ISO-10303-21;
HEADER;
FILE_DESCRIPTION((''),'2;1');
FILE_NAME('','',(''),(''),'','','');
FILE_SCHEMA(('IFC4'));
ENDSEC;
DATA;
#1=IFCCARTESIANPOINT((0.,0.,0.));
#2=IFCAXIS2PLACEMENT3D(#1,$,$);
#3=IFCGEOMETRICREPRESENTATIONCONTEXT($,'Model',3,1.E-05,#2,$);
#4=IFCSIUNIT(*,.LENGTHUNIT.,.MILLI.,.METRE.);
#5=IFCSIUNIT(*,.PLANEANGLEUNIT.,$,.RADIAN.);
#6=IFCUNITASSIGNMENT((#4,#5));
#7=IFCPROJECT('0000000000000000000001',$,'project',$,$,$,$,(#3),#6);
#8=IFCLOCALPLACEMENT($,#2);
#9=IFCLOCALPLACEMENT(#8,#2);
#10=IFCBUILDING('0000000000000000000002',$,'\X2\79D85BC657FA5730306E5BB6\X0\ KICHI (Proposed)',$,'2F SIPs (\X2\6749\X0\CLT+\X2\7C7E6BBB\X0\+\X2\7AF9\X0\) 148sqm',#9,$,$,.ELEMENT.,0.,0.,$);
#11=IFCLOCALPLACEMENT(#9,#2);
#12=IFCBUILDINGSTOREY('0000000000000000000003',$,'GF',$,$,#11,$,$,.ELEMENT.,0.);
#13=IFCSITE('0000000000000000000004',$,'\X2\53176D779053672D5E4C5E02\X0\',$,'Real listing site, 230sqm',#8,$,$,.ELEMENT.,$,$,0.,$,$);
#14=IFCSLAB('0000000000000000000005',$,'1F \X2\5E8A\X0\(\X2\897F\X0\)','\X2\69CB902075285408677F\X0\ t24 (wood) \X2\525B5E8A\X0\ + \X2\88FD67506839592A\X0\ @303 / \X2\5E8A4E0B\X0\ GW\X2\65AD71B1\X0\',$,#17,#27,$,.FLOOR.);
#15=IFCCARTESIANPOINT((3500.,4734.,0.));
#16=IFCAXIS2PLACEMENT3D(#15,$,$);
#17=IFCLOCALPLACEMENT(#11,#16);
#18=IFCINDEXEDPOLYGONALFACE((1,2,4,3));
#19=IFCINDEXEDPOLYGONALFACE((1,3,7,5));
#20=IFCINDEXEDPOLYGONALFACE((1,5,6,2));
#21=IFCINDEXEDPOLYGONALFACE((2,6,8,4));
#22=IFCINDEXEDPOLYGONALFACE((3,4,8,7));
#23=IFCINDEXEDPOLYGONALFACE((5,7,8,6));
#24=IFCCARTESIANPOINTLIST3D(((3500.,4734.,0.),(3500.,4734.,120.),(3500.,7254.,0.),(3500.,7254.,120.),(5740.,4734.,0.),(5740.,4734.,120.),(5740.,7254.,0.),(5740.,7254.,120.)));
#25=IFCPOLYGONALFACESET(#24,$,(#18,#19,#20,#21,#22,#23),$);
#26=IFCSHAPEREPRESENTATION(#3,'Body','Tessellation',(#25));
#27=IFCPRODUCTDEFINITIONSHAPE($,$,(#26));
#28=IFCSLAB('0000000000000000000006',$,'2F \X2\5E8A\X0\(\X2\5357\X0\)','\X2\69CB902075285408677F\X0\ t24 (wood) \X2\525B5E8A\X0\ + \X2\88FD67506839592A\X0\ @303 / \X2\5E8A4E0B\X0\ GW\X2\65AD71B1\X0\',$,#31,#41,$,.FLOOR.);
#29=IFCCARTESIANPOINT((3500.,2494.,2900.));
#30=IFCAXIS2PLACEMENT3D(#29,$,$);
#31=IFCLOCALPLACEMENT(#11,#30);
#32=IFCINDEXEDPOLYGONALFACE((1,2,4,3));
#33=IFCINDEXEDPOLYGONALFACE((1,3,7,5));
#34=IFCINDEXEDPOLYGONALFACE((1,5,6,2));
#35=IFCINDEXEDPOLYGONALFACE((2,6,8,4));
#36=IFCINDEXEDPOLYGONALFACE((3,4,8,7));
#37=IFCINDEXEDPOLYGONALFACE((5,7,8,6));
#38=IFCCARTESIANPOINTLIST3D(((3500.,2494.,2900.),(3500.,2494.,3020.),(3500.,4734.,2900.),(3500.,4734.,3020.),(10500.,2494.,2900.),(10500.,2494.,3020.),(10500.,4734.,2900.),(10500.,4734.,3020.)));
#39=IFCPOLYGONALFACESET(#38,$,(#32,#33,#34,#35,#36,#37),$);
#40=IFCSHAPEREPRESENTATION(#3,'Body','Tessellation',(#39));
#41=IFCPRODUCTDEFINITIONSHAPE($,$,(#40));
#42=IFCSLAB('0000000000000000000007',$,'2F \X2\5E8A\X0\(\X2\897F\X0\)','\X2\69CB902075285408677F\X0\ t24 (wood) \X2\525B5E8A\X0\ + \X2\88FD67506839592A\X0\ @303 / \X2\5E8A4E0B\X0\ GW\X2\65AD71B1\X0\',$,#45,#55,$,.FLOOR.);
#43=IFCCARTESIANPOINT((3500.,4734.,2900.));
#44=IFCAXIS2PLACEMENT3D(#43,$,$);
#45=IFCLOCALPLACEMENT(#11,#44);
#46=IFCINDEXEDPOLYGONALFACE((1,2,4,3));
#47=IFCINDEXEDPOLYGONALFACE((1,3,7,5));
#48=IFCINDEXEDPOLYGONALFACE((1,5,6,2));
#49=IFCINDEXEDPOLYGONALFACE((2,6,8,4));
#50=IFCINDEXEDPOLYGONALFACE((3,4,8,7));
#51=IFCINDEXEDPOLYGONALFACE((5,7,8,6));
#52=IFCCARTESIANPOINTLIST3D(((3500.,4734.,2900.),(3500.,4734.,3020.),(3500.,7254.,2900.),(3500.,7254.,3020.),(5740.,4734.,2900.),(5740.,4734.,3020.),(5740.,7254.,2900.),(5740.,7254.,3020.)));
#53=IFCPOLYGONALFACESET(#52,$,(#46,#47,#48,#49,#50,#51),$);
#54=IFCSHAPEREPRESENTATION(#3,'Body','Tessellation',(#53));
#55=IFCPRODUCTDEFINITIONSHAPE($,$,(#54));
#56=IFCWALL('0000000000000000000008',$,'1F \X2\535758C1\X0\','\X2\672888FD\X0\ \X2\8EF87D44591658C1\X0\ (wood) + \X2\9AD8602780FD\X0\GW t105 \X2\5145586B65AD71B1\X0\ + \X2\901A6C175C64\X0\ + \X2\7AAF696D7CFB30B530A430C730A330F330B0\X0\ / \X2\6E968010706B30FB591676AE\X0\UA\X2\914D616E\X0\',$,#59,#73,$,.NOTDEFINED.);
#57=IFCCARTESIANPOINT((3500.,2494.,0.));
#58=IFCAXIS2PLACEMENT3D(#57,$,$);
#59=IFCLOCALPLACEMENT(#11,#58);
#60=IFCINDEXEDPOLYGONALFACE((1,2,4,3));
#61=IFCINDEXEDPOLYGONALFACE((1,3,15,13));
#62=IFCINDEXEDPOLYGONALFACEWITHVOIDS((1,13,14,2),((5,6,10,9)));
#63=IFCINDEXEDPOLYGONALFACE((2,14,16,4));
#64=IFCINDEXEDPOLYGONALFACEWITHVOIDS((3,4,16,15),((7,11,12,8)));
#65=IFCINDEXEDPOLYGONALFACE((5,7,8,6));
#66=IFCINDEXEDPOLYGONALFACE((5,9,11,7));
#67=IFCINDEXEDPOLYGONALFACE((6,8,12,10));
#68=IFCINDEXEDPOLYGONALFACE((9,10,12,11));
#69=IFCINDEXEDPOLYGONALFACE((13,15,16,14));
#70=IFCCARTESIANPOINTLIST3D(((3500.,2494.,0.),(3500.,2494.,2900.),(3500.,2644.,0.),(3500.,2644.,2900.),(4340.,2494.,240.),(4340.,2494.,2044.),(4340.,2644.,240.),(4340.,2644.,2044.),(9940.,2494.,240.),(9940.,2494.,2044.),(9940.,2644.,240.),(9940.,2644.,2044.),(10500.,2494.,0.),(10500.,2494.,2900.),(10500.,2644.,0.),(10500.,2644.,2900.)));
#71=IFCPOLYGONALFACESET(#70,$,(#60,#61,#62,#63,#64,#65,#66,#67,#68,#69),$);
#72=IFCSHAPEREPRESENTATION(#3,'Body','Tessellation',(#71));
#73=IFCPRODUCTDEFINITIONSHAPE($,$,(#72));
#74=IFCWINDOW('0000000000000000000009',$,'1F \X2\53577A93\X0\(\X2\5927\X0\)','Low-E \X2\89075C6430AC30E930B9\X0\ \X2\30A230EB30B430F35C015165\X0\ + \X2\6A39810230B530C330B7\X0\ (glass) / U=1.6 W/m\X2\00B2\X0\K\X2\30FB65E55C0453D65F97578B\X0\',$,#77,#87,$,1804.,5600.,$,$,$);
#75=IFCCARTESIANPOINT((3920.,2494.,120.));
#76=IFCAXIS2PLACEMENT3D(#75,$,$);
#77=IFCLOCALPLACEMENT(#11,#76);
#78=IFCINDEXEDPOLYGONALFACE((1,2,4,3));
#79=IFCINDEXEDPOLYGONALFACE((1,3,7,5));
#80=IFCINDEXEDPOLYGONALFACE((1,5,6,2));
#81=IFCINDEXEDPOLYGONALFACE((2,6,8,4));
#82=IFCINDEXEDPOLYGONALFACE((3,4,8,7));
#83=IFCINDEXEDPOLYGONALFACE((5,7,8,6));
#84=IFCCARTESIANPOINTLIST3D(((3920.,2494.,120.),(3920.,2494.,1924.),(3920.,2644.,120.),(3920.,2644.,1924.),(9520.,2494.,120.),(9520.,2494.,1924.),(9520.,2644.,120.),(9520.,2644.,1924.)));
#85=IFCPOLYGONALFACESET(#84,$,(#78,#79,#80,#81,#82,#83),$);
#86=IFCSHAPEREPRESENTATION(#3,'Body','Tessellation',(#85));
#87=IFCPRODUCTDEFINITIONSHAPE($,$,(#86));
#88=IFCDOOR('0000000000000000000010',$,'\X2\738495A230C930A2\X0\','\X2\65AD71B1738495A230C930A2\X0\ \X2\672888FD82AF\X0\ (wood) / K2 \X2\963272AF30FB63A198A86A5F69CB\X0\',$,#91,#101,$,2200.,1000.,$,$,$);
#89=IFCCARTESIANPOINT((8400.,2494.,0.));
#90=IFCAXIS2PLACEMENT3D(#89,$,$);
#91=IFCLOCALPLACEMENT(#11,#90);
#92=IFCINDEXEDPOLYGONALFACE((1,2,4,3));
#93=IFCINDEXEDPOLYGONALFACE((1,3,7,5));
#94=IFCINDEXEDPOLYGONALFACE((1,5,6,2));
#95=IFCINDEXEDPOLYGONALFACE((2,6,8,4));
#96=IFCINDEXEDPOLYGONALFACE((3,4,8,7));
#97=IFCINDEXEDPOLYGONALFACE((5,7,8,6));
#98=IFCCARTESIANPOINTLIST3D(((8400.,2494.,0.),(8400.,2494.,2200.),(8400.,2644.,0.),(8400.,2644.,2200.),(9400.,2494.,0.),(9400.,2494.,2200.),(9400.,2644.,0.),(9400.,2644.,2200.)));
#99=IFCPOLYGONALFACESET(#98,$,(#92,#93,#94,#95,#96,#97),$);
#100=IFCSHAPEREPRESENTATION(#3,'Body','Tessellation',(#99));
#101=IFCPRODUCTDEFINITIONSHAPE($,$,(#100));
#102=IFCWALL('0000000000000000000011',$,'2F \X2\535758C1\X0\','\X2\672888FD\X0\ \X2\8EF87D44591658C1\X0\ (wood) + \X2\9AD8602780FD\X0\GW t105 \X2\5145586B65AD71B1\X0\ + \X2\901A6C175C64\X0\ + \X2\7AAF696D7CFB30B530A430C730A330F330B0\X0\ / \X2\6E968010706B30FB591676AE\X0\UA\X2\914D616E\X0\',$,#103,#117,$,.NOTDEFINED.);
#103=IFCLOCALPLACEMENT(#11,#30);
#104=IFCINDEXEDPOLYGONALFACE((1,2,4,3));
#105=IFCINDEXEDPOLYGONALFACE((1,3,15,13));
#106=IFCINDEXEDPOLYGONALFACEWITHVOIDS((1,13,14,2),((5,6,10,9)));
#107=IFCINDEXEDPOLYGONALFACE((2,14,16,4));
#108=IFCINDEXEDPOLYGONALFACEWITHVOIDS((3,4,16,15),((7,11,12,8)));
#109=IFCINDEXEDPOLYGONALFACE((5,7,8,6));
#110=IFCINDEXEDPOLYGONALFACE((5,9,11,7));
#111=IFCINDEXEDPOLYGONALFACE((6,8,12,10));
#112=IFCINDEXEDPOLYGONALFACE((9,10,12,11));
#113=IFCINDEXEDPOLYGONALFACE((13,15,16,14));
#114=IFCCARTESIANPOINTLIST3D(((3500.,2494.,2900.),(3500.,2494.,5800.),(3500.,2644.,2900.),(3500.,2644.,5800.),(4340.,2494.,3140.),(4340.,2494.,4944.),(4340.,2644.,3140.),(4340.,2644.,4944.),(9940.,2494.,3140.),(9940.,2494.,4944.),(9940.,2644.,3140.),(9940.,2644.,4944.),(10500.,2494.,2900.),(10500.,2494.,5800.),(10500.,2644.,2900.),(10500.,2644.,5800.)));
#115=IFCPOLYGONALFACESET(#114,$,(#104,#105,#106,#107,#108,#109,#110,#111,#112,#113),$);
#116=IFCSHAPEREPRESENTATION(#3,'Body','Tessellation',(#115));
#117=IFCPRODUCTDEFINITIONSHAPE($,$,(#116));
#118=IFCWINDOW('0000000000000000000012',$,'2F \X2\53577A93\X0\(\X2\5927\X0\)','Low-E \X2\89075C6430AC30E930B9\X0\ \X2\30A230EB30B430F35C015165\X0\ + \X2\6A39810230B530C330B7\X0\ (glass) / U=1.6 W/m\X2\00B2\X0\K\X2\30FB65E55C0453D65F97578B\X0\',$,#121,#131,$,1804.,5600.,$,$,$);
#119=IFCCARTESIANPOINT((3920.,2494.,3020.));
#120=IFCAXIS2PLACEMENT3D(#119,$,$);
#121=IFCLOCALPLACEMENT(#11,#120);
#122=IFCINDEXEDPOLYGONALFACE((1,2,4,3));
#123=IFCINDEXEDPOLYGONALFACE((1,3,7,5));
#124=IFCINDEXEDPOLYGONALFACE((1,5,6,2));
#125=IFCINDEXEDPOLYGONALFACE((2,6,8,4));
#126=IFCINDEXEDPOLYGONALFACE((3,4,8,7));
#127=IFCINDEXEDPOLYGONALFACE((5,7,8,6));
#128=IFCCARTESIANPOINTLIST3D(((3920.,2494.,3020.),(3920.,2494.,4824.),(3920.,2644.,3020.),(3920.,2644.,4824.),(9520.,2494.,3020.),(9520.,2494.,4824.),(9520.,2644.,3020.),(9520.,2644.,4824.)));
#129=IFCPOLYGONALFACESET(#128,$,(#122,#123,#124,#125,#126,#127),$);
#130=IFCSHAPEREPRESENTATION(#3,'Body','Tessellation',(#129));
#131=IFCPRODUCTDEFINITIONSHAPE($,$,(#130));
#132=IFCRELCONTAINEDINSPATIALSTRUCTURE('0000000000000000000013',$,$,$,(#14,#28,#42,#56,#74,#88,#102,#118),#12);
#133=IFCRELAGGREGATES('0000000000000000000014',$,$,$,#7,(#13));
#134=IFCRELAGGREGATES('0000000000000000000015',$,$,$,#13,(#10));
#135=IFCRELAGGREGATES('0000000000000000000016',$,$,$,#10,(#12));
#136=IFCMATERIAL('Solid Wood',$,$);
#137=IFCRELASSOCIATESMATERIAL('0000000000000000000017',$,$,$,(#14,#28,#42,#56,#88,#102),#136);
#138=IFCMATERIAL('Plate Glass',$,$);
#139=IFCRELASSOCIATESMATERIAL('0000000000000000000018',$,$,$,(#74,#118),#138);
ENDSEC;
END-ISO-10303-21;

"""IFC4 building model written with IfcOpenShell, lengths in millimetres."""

from ifc_helpers import new_model, si_unit, frame, frame_2d, origin, place, context, project, spatial, rectangle, extrude, material, element, fill, save


model = new_model("IFC4")

# Units and contexts
model_context = context("Model", 3, precision=1e-05, world=origin())
ifc_project = project(units=[si_unit("LENGTHUNIT", "METRE", prefix="MILLI"), si_unit("PLANEANGLEUNIT", "RADIAN")], contexts=[model_context])

# Site, building, storey
site_placement = place(None, origin())
site = spatial("IfcSite", under=ifc_project, at=site_placement, Name="北海道札幌市", ObjectType="Real listing site, 230sqm", CompositionType="ELEMENT", RefElevation=0.0)
building_placement = place(site_placement, origin())
building = spatial("IfcBuilding", under=site, at=building_placement, Name="秘密基地の家 KICHI (Proposed)", ObjectType="2F SIPs (杉CLT+籾殻+竹) 148sqm", CompositionType="ELEMENT", ElevationOfRefHeight=0.0, ElevationOfTerrain=0.0)
storey_placement = place(building_placement, origin())
storey = spatial("IfcBuildingStorey", under=building, at=storey_placement, Name="GF", CompositionType="ELEMENT", Elevation=0.0)

# Slabs
ifc_material_1 = material(Name="Solid Wood")
slab_1_placement = place(storey_placement, frame((3500.0, 4734.0, 0.0)))
element("IfcSlab", 1, at=slab_1_placement, inside=storey, material=ifc_material_1, Name="1F 床(西)", Description="構造用合板 t24 (wood) 剛床 + 製材根太 @303 / 床下 GW断熱", PredefinedType="FLOOR", context=model_context, shape_type="SweptSolid", body=[
    extrude(rectangle(XDim=2240.0, YDim=2520.0, at=frame_2d((1120.0, 1260.0))), frame((3500.0, 4734.0, 0.0)), (0.0, 0.0, 1.0), 120.0),
])
slab_2_placement = place(storey_placement, frame((3500.0, 2494.0, 2900.0)))
element("IfcSlab", 2, at=slab_2_placement, inside=storey, material=ifc_material_1, Name="2F 床(南)", Description="構造用合板 t24 (wood) 剛床 + 製材根太 @303 / 床下 GW断熱", PredefinedType="FLOOR", context=model_context, shape_type="SweptSolid", body=[
    extrude(rectangle(XDim=7000.0, YDim=2240.0, at=frame_2d((3500.0, 1120.0))), frame((3500.0, 2494.0, 2900.0)), (0.0, 0.0, 1.0), 120.0),
])
slab_3_placement = place(storey_placement, frame((3500.0, 4734.0, 2900.0)))
element("IfcSlab", 3, at=slab_3_placement, inside=storey, material=ifc_material_1, Name="2F 床(西)", Description="構造用合板 t24 (wood) 剛床 + 製材根太 @303 / 床下 GW断熱", PredefinedType="FLOOR", context=model_context, shape_type="SweptSolid", body=[
    extrude(rectangle(XDim=2240.0, YDim=2520.0, at=frame_2d((1120.0, 1260.0))), frame((3500.0, 4734.0, 2900.0)), (0.0, 0.0, 1.0), 120.0),
])

# Wall, openings, window, door
wall_1_placement = place(storey_placement, frame((3500.0, 2494.0, 0.0)))
wall_1 = element("IfcWall", 4, at=wall_1_placement, inside=storey, material=ifc_material_1, Name="1F 南壁", Description="木製 軸組外壁 (wood) + 高性能GW t105 充填断熱 + 通気層 + 窯業系サイディング / 準耐火・外皮UA配慮", PredefinedType="NOTDEFINED", context=model_context, shape_type="SweptSolid", body=[
    extrude(rectangle(XDim=7000.0, YDim=150.0, at=frame_2d((3500.0, 75.0))), frame((3500.0, 2494.0, 0.0)), (0.0, 0.0, 1.0), 2900.0),
])
opening_1_placement = place(storey_placement, frame((3920.0, 2494.0, 120.0)))
opening_1 = element("IfcOpeningElement", 5, at=opening_1_placement, cuts=wall_1, PredefinedType="NOTDEFINED", context=model_context, shape_type="SweptSolid", body=[
    extrude(rectangle(XDim=5600.0, YDim=150.0, at=frame_2d((2800.0, 75.0))), frame((3920.0, 2494.0, 120.0)), (0.0, 0.0, 1.0), 1804.0),
])
opening_2_placement = place(storey_placement, frame((8400.0, 2494.0, 0.0)))
opening_2 = element("IfcOpeningElement", 6, at=opening_2_placement, cuts=wall_1, PredefinedType="NOTDEFINED", context=model_context, shape_type="SweptSolid", body=[
    extrude(rectangle(XDim=1000.0, YDim=150.0, at=frame_2d((500.0, 75.0))), frame((8400.0, 2494.0, 0.0)), (0.0, 0.0, 1.0), 2200.0),
])
ifc_material_2 = material(Name="Plate Glass")
window_1_placement = place(storey_placement, frame((3920.0, 2494.0, 120.0)))
window_1 = element("IfcWindow", 7, at=window_1_placement, inside=storey, material=ifc_material_2, Name="1F 南窓(大)", Description="Low-E 複層ガラス アルゴン封入 + 樹脂サッシ (glass) / U=1.6 W/m²K・日射取得型", OverallHeight=1804.0, OverallWidth=5600.0, context=model_context, shape_type="SweptSolid", body=[
    extrude(rectangle(XDim=5600.0, YDim=150.0, at=frame_2d((2800.0, 75.0))), frame((3920.0, 2494.0, 120.0)), (0.0, 0.0, 1.0), 1804.0),
])
fill(opening_1, window_1)
door_placement = place(storey_placement, frame((8400.0, 2494.0, 0.0)))
door = element("IfcDoor", 8, at=door_placement, inside=storey, material=ifc_material_1, Name="玄関ドア", Description="断熱玄関ドア 木製芯 (wood) / K2 防犯・採風機構", OverallHeight=2200.0, OverallWidth=1000.0, context=model_context, shape_type="SweptSolid", body=[
    extrude(rectangle(XDim=1000.0, YDim=150.0, at=frame_2d((500.0, 75.0))), frame((8400.0, 2494.0, 0.0)), (0.0, 0.0, 1.0), 2200.0),
])
fill(opening_2, door)

# Wall, opening, window
wall_2_placement = place(storey_placement, frame((3500.0, 2494.0, 2900.0)))
wall_2 = element("IfcWall", 9, at=wall_2_placement, inside=storey, material=ifc_material_1, Name="2F 南壁", Description="木製 軸組外壁 (wood) + 高性能GW t105 充填断熱 + 通気層 + 窯業系サイディング / 準耐火・外皮UA配慮", PredefinedType="NOTDEFINED", context=model_context, shape_type="SweptSolid", body=[
    extrude(rectangle(XDim=7000.0, YDim=150.0, at=frame_2d((3500.0, 75.0))), frame((3500.0, 2494.0, 2900.0)), (0.0, 0.0, 1.0), 2900.0),
])
opening_3_placement = place(storey_placement, frame((3920.0, 2494.0, 3020.0)))
opening_3 = element("IfcOpeningElement", 10, at=opening_3_placement, cuts=wall_2, PredefinedType="NOTDEFINED", context=model_context, shape_type="SweptSolid", body=[
    extrude(rectangle(XDim=5600.0, YDim=150.0, at=frame_2d((2800.0, 75.0))), frame((3920.0, 2494.0, 3020.0)), (0.0, 0.0, 1.0), 1804.0),
])
window_2_placement = place(storey_placement, frame((3920.0, 2494.0, 3020.0)))
window_2 = element("IfcWindow", 11, at=window_2_placement, inside=storey, material=ifc_material_2, Name="2F 南窓(大)", Description="Low-E 複層ガラス アルゴン封入 + 樹脂サッシ (glass) / U=1.6 W/m²K・日射取得型", OverallHeight=1804.0, OverallWidth=5600.0, context=model_context, shape_type="SweptSolid", body=[
    extrude(rectangle(XDim=5600.0, YDim=150.0, at=frame_2d((2800.0, 75.0))), frame((3920.0, 2494.0, 3020.0)), (0.0, 0.0, 1.0), 1804.0),
])
fill(opening_3, window_2)

save(model, "model.ifc")
